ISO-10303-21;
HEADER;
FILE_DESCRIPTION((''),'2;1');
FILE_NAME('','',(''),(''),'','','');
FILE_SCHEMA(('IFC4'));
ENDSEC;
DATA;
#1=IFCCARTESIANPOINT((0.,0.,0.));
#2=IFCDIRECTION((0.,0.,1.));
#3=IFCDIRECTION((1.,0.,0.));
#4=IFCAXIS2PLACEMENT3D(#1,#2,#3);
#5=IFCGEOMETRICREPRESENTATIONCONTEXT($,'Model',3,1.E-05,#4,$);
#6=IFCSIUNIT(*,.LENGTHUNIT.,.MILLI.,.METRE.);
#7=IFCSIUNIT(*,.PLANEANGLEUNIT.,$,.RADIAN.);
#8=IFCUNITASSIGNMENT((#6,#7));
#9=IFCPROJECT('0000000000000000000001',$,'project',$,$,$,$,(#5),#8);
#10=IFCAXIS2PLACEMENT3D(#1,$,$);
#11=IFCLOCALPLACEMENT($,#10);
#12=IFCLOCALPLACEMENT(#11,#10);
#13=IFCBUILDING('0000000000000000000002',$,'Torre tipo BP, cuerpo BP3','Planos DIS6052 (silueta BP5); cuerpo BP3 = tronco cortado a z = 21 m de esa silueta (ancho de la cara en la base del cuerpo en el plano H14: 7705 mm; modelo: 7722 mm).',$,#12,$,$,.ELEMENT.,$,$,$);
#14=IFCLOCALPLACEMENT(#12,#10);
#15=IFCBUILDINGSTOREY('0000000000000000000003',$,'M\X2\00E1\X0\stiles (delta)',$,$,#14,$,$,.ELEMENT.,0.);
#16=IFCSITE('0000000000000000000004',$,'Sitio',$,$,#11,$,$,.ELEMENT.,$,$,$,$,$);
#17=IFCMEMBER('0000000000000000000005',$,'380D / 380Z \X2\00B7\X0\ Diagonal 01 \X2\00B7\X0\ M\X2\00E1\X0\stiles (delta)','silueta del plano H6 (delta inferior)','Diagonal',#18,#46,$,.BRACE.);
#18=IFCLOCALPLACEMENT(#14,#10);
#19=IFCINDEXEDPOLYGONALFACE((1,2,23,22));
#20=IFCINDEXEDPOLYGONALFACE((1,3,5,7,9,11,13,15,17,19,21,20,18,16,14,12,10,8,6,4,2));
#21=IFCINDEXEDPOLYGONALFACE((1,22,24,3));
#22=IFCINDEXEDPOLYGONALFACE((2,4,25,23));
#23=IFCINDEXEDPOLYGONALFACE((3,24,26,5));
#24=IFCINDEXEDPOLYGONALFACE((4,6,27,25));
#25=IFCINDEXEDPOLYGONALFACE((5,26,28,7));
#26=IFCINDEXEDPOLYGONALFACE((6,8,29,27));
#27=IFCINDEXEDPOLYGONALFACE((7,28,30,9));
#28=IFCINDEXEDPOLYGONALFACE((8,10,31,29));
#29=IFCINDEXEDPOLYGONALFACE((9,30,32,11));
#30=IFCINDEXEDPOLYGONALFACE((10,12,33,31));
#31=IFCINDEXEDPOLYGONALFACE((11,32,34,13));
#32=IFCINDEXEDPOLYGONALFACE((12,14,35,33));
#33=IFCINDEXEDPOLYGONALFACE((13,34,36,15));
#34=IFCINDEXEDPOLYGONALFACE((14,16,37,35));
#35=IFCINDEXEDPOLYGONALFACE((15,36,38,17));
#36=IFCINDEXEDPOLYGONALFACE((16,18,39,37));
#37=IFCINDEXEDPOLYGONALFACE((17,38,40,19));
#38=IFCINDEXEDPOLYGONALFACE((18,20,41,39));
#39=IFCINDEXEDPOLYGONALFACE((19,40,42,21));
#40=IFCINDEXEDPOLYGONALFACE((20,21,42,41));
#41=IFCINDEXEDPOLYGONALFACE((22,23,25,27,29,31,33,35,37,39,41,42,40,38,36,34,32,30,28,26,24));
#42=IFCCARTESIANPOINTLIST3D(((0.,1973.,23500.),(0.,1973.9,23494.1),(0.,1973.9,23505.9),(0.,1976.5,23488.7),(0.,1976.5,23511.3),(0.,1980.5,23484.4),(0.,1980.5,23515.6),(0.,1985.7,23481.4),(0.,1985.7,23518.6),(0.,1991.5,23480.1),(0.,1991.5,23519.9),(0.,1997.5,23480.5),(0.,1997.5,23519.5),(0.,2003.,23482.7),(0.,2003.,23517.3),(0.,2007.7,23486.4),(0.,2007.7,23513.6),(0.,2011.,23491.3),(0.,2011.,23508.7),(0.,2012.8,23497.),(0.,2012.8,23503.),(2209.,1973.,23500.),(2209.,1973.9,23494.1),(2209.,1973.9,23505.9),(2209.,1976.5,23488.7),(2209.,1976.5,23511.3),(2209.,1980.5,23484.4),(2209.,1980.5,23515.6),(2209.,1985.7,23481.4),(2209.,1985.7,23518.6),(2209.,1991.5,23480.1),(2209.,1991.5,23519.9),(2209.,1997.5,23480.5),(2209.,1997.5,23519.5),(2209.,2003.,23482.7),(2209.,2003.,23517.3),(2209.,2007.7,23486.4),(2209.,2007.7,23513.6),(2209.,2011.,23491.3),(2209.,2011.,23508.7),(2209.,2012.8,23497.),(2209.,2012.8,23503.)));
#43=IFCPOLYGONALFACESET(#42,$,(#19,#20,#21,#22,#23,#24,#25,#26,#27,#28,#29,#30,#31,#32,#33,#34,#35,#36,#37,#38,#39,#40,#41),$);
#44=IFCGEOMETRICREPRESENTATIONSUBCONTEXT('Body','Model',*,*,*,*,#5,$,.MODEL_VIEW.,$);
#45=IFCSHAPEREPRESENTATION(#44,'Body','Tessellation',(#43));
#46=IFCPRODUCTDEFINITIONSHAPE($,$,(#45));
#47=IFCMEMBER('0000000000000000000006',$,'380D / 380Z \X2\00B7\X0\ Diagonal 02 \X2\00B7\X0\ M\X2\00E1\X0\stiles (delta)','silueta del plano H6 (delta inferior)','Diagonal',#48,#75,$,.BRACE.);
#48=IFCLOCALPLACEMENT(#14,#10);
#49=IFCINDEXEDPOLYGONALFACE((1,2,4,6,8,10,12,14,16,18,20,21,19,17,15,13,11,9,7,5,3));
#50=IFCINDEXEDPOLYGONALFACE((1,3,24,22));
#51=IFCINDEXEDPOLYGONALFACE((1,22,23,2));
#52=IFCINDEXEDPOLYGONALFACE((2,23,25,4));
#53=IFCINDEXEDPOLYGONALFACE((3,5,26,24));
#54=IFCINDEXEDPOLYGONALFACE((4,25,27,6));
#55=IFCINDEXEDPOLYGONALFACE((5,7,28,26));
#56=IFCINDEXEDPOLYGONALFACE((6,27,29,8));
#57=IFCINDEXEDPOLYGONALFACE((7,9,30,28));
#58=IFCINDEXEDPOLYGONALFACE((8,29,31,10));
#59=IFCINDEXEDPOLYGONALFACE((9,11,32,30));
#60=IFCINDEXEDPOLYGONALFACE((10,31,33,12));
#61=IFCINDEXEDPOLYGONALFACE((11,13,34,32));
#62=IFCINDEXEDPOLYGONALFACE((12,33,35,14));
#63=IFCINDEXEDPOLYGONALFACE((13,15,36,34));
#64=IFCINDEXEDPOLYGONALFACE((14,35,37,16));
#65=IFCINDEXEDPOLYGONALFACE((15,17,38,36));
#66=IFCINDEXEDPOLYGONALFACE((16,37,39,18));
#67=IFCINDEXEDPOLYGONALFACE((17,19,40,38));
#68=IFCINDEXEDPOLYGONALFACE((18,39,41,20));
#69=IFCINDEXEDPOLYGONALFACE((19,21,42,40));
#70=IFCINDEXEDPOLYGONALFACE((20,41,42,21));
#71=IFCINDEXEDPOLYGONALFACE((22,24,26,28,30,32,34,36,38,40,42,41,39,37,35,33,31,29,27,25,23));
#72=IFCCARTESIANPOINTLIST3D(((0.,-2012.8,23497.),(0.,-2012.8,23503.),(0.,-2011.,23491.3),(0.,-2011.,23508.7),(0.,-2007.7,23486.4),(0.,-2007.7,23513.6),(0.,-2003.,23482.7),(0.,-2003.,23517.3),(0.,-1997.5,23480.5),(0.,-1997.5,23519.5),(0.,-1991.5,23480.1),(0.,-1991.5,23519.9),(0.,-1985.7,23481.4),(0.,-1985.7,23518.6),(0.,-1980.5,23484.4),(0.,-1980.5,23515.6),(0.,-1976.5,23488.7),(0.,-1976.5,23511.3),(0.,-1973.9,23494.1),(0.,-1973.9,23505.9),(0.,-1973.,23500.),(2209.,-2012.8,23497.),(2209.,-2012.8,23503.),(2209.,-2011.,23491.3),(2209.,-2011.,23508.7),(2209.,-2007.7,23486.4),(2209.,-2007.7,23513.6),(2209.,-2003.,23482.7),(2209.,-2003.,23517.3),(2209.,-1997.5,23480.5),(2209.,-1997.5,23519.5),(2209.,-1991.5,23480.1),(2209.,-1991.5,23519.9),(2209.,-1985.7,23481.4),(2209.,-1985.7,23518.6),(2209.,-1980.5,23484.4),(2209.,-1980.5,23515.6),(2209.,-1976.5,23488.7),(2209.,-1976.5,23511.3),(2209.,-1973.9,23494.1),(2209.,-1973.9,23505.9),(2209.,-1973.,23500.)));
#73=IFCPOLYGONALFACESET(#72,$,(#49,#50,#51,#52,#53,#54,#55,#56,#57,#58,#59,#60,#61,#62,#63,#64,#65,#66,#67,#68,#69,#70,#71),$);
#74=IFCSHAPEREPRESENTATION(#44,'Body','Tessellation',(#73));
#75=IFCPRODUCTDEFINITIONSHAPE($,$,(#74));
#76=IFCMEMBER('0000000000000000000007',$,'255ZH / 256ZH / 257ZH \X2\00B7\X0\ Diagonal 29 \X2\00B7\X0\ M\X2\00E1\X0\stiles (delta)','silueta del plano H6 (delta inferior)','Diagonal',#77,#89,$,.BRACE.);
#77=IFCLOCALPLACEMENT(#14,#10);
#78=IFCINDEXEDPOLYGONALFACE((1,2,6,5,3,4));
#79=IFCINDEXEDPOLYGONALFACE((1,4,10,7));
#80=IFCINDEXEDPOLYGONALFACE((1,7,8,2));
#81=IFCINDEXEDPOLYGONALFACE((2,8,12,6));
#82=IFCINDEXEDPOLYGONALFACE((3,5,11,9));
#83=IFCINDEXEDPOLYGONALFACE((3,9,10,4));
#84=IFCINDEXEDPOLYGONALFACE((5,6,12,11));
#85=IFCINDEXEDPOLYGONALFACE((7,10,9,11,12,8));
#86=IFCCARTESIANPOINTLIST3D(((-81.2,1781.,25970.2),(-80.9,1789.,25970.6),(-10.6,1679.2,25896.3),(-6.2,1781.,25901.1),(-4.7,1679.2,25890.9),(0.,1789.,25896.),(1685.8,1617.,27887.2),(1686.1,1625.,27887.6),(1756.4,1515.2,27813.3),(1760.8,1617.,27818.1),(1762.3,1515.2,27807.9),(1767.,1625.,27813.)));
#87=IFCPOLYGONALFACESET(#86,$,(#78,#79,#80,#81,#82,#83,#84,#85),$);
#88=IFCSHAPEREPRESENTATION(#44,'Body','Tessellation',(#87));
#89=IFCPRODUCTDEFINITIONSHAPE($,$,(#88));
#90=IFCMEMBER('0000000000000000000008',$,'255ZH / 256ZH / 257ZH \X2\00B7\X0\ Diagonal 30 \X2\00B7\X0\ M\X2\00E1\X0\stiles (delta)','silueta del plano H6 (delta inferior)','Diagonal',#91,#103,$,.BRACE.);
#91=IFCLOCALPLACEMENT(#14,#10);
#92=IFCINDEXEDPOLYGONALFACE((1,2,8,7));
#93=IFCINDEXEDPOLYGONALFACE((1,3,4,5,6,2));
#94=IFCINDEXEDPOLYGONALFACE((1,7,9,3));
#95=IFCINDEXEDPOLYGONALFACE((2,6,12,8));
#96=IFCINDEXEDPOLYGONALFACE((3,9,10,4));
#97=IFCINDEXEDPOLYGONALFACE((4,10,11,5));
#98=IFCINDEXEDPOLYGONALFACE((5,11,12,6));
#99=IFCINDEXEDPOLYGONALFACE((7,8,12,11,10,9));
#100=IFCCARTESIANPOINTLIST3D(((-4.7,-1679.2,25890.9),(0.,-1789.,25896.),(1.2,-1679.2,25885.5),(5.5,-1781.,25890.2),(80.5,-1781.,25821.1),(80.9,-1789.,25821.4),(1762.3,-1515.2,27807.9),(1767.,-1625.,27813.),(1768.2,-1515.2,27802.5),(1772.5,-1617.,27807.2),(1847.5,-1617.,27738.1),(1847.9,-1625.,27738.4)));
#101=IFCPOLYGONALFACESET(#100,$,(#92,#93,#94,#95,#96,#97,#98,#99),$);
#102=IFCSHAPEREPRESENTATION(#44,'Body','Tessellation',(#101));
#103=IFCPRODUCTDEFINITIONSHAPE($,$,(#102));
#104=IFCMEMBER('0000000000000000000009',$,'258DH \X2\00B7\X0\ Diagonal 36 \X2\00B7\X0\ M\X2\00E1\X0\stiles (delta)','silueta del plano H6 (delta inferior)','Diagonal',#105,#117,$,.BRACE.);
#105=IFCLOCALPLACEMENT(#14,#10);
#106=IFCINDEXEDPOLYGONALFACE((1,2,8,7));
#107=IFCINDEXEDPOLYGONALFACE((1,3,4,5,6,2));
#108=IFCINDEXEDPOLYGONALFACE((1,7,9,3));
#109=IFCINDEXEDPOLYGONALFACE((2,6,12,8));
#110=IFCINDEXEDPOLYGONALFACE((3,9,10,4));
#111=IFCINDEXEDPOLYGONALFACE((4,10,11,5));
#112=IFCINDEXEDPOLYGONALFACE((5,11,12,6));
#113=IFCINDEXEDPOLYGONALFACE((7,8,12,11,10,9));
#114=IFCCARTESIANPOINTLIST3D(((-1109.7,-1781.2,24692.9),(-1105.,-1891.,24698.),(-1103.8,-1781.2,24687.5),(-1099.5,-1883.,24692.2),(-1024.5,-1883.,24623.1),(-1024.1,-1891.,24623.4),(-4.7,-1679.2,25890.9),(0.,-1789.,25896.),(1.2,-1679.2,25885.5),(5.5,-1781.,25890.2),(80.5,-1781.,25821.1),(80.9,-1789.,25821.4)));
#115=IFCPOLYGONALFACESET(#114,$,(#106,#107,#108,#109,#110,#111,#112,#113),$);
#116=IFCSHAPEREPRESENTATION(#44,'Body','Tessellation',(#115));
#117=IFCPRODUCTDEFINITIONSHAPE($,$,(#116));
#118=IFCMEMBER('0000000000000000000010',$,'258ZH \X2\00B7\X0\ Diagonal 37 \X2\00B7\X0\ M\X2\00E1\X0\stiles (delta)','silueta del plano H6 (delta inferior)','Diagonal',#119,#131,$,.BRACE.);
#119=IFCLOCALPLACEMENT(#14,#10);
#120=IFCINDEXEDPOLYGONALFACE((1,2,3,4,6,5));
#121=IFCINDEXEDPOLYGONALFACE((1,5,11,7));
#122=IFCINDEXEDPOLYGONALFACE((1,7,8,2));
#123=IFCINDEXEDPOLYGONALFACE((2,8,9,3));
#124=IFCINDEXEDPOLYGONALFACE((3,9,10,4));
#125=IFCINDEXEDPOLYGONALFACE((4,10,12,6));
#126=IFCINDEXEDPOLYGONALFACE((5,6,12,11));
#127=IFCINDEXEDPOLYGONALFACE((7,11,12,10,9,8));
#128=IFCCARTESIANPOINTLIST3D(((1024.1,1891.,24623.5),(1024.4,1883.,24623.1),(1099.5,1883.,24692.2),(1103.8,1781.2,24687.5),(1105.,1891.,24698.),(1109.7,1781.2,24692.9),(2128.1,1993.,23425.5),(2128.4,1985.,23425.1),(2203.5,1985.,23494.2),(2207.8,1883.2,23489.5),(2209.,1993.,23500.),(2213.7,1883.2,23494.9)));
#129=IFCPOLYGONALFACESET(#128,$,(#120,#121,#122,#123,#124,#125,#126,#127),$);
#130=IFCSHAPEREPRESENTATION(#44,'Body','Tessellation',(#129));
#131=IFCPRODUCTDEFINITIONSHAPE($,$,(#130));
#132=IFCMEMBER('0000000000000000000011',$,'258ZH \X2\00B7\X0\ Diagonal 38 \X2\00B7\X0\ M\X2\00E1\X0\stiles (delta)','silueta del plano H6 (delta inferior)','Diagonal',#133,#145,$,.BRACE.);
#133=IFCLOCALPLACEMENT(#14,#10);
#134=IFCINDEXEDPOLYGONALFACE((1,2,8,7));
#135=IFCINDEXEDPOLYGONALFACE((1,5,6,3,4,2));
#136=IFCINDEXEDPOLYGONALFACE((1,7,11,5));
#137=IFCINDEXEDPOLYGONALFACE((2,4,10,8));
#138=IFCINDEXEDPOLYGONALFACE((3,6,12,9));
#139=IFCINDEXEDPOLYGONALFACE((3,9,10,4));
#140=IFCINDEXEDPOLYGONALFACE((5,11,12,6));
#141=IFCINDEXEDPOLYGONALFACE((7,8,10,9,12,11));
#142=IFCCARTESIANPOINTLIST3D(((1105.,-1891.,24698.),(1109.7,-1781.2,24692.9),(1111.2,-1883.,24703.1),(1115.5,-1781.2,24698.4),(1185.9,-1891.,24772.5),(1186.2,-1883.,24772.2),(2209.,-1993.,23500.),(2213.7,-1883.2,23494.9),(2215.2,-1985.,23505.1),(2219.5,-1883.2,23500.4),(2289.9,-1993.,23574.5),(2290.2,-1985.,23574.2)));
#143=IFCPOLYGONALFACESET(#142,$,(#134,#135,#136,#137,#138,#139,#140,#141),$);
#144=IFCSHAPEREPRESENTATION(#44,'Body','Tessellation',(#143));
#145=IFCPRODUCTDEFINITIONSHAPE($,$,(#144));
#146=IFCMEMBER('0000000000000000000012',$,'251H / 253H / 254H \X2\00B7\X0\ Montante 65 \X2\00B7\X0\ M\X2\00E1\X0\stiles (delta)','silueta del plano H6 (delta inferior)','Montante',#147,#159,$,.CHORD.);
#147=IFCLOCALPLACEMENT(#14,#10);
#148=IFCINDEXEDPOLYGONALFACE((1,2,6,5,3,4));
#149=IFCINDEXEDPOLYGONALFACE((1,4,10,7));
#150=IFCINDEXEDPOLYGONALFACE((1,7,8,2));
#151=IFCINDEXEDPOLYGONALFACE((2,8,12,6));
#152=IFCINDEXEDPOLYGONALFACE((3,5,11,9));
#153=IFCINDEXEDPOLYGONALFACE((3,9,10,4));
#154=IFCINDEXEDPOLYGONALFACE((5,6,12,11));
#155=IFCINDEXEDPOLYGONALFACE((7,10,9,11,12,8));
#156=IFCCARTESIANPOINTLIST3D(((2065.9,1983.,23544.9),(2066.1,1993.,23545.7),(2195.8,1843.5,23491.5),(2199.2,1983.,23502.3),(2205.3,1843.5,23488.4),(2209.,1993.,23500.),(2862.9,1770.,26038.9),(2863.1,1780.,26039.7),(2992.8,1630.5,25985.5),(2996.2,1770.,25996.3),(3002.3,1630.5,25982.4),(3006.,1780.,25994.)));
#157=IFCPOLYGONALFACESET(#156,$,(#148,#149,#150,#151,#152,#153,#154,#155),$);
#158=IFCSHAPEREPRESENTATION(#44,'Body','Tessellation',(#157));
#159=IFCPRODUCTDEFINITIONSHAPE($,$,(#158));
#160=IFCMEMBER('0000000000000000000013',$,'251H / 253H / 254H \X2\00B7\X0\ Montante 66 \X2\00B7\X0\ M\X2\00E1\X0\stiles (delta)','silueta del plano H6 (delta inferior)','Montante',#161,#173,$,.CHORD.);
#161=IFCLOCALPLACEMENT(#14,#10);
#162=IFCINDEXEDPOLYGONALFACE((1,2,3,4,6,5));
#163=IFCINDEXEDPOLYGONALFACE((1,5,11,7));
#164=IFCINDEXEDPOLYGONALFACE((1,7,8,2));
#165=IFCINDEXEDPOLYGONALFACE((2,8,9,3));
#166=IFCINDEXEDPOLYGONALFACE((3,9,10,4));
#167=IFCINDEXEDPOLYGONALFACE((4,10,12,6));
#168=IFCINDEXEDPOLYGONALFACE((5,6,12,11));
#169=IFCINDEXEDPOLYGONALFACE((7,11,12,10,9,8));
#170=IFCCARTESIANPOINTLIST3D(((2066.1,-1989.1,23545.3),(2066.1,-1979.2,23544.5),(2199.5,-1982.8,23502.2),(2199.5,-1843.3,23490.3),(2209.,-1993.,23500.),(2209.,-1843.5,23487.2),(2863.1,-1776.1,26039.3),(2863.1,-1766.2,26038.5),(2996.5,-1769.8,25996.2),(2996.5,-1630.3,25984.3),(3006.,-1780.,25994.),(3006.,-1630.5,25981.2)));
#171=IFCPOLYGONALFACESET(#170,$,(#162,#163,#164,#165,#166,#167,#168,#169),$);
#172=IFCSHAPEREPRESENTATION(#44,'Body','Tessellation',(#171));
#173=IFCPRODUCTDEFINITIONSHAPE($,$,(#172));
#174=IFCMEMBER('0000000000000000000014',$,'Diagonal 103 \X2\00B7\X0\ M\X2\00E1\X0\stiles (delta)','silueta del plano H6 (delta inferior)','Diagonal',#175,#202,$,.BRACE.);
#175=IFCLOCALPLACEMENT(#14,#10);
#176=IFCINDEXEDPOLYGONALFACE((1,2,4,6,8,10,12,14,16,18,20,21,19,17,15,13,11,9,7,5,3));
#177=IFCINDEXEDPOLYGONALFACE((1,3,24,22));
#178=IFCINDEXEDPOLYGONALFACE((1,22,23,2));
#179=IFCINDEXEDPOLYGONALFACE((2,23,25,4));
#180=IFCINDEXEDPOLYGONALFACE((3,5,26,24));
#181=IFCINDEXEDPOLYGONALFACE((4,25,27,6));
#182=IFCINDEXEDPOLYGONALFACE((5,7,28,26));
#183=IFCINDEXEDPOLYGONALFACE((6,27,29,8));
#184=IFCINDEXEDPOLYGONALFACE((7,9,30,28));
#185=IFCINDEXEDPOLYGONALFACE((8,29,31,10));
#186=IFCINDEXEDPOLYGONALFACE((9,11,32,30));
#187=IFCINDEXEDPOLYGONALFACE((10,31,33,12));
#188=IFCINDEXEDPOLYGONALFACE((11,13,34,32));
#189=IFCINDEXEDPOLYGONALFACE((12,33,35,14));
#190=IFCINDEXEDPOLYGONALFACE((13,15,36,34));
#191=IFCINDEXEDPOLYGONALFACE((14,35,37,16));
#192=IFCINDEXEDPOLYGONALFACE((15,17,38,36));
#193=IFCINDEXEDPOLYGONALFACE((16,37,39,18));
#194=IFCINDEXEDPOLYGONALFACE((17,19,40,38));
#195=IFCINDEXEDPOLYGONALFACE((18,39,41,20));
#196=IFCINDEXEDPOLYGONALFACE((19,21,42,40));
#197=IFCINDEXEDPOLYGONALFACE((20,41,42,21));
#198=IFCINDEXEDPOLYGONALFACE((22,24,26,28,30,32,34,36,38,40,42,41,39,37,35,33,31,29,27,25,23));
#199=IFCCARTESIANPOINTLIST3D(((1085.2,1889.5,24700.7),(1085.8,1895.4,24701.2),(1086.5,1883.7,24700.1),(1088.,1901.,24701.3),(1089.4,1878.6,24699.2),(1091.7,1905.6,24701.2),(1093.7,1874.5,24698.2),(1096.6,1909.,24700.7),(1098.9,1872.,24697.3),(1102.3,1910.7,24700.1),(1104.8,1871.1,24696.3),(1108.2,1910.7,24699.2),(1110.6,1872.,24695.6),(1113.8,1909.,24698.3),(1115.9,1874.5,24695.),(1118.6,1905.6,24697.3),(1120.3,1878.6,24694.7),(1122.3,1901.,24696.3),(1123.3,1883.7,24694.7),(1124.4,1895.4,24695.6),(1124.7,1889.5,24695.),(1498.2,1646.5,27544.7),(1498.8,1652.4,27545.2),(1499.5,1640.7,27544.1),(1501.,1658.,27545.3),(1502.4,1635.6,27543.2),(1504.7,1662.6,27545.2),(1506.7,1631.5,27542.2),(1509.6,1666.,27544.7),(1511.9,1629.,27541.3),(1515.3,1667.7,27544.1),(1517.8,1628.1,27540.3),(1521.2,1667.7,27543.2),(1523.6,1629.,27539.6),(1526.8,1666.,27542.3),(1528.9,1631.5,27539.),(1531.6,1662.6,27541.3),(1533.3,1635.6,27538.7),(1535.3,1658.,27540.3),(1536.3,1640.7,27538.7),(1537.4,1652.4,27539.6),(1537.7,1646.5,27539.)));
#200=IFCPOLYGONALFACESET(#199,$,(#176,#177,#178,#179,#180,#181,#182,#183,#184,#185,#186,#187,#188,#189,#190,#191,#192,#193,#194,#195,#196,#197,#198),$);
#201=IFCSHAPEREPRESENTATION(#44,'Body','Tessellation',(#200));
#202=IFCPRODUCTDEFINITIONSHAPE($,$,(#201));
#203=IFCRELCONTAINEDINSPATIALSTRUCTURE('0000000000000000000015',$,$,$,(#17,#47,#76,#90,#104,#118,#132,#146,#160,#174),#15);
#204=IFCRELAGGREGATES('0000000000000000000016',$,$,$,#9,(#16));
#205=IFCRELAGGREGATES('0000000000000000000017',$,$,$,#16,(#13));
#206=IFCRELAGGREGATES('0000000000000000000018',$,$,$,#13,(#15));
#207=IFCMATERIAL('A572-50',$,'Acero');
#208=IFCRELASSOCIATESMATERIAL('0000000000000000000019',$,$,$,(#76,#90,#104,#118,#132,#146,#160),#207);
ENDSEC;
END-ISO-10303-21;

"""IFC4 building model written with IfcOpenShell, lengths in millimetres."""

from ifc_helpers import new_model, si_unit, frame, frame_2d, origin, origin_with_axes, place, context, subcontext, project, spatial, circle, l_section, extrude, material, element, save


model = new_model("IFC4")

# Units and contexts
model_context = context("Model", 3, precision=1e-05, world=origin_with_axes())
body_context = subcontext(model_context, "Body", "Model", "MODEL_VIEW")
ifc_project = project(units=[si_unit("LENGTHUNIT", "METRE", prefix="MILLI"), si_unit("PLANEANGLEUNIT", "RADIAN")], contexts=[model_context])

# Site, building, storey
site_placement = place(None, origin())
site = spatial("IfcSite", under=ifc_project, at=site_placement, Name="Sitio", CompositionType="ELEMENT")
building_placement = place(site_placement, origin())
building = spatial("IfcBuilding", under=site, at=building_placement, Name="Torre tipo BP, cuerpo BP3", Description="Planos DIS6052 (silueta BP5); cuerpo BP3 = tronco cortado a z = 21 m de esa silueta (ancho de la cara en la base del cuerpo en el plano H14: 7705 mm; modelo: 7722 mm).", CompositionType="ELEMENT")
storey_placement = place(building_placement, origin())
storey = spatial("IfcBuildingStorey", under=building, at=storey_placement, Name="Mástiles (delta)", CompositionType="ELEMENT", Elevation=0.0)

# Members
for number, where, z_axis, x_axis, name in (
    (1, (2209.0, 1993.0, 23500.0), (-1.0, 0.0, 0.0), (0.0, -1.0, 0.0), "380D / 380Z · Diagonal 01 · Mástiles (delta)"),
    (2, (2209.0, -1993.0, 23500.0), (-1.0, 0.0, 0.0), (0.0, 1.0, 0.0), "380D / 380Z · Diagonal 02 · Mástiles (delta)"),
):
    element("IfcMember", number, at=place(storey_placement, frame(where, z_axis=z_axis, x_axis=x_axis)), inside=storey, Name=name, Description="silueta del plano H6 (delta inferior)", ObjectType="Diagonal", PredefinedType="BRACE", context=body_context, shape_type="SweptSolid", body=[
        extrude(circle(Radius=20.0), None, (0.0, 0.0, 1.0), 2209.0),
    ])
ifc_material = material(Name="A572-50", Category="Acero")
for number, where, z_axis, x_axis, name in (
    (3, (1767.0, 1625.0, 27813.0), (-0.676417, 0.06278, -0.733838), (-0.042549, -0.998027, -0.046161), "255ZH / 256ZH / 257ZH · Diagonal 29 · Mástiles (delta)"),
    (4, (1767.0, -1625.0, 27813.0), (-0.676417, -0.06278, -0.733838), (-0.042549, 0.998027, -0.046161), "255ZH / 256ZH / 257ZH · Diagonal 30 · Mástiles (delta)"),
):
    element("IfcMember", number, at=place(storey_placement, frame(where, z_axis=z_axis, x_axis=x_axis)), inside=storey, material=ifc_material, Name=name, Description="silueta del plano H6 (delta inferior)", ObjectType="Diagonal", PredefinedType="BRACE", context=body_context, shape_type="SweptSolid", body=[
        extrude(l_section(Depth=110.0, Width=110.0, Thickness=8.0, at=frame_2d((55.0, 55.0))), None, (0.0, 0.0, 1.0), 2612.3),
    ])
member_1_placement = place(storey_placement, frame((0.0, -1789.0, 25896.0), z_axis=(-0.676676, -0.062462, -0.733627), x_axis=(-0.042349, 0.998047, -0.045914)))
element("IfcMember", 5, at=member_1_placement, inside=storey, material=ifc_material, Name="258DH · Diagonal 36 · Mástiles (delta)", Description="silueta del plano H6 (delta inferior)", ObjectType="Diagonal", PredefinedType="BRACE", context=body_context, shape_type="SweptSolid", body=[
    extrude(l_section(Depth=110.0, Width=110.0, Thickness=8.0, at=frame_2d((55.0, 55.0))), None, (0.0, 0.0, 1.0), 1633.0),
])
for number, where, z_axis, x_axis, name in (
    (6, (1105.0, 1891.0, 24698.0), (0.676344, 0.062488, -0.733931), (0.042346, -0.998046, -0.045952), "258ZH · Diagonal 37 · Mástiles (delta)"),
    (7, (1105.0, -1891.0, 24698.0), (0.676344, -0.062488, -0.733931), (0.042346, 0.998046, -0.045952), "258ZH · Diagonal 38 · Mástiles (delta)"),
):
    element("IfcMember", number, at=place(storey_placement, frame(where, z_axis=z_axis, x_axis=x_axis)), inside=storey, material=ifc_material, Name=name, Description="silueta del plano H6 (delta inferior)", ObjectType="Diagonal", PredefinedType="BRACE", context=body_context, shape_type="SweptSolid", body=[
        extrude(l_section(Depth=110.0, Width=110.0, Thickness=8.0, at=frame_2d((55.0, 55.0))), None, (0.0, 0.0, 1.0), 1632.3),
    ])
for number, where, z_axis, x_axis, name in (
    (8, (3006.0, 1780.0, 25994.0), (-0.303399, 0.081084, -0.949407), (-0.024682, -0.996707, -0.077236), "251H / 253H / 254H · Montante 65 · Mástiles (delta)"),
    (9, (3006.0, -1780.0, 25994.0), (-0.303399, -0.081084, -0.949407), (-0.952864, 0.025818, 0.302299), "251H / 253H / 254H · Montante 66 · Mástiles (delta)"),
):
    element("IfcMember", number, at=place(storey_placement, frame(where, z_axis=z_axis, x_axis=x_axis)), inside=storey, material=ifc_material, Name=name, Description="silueta del plano H6 (delta inferior)", ObjectType="Montante", PredefinedType="CHORD", context=body_context, shape_type="SweptSolid", body=[
        extrude(l_section(Depth=150.0, Width=150.0, Thickness=10.0, at=frame_2d((75.0, 75.0))), None, (0.0, 0.0, 1.0), 2626.9),
    ])
for number, where, z_axis, x_axis, name in (
    (10, (1518.0, 1648.0, 27542.0), (-0.1432, 0.084255, -0.986101), (-0.012108, -0.996444, -0.083381), "Diagonal 103 · Mástiles (delta)"),
):
    element("IfcMember", number, at=place(storey_placement, frame(where, z_axis=z_axis, x_axis=x_axis)), inside=storey, Name=name, Description="silueta del plano H6 (delta inferior)", ObjectType="Diagonal", PredefinedType="BRACE", context=body_context, shape_type="SweptSolid", body=[
        extrude(circle(Radius=20.0), None, (0.0, 0.0, 1.0), 2884.1),
    ])

save(model, "model.ifc")
